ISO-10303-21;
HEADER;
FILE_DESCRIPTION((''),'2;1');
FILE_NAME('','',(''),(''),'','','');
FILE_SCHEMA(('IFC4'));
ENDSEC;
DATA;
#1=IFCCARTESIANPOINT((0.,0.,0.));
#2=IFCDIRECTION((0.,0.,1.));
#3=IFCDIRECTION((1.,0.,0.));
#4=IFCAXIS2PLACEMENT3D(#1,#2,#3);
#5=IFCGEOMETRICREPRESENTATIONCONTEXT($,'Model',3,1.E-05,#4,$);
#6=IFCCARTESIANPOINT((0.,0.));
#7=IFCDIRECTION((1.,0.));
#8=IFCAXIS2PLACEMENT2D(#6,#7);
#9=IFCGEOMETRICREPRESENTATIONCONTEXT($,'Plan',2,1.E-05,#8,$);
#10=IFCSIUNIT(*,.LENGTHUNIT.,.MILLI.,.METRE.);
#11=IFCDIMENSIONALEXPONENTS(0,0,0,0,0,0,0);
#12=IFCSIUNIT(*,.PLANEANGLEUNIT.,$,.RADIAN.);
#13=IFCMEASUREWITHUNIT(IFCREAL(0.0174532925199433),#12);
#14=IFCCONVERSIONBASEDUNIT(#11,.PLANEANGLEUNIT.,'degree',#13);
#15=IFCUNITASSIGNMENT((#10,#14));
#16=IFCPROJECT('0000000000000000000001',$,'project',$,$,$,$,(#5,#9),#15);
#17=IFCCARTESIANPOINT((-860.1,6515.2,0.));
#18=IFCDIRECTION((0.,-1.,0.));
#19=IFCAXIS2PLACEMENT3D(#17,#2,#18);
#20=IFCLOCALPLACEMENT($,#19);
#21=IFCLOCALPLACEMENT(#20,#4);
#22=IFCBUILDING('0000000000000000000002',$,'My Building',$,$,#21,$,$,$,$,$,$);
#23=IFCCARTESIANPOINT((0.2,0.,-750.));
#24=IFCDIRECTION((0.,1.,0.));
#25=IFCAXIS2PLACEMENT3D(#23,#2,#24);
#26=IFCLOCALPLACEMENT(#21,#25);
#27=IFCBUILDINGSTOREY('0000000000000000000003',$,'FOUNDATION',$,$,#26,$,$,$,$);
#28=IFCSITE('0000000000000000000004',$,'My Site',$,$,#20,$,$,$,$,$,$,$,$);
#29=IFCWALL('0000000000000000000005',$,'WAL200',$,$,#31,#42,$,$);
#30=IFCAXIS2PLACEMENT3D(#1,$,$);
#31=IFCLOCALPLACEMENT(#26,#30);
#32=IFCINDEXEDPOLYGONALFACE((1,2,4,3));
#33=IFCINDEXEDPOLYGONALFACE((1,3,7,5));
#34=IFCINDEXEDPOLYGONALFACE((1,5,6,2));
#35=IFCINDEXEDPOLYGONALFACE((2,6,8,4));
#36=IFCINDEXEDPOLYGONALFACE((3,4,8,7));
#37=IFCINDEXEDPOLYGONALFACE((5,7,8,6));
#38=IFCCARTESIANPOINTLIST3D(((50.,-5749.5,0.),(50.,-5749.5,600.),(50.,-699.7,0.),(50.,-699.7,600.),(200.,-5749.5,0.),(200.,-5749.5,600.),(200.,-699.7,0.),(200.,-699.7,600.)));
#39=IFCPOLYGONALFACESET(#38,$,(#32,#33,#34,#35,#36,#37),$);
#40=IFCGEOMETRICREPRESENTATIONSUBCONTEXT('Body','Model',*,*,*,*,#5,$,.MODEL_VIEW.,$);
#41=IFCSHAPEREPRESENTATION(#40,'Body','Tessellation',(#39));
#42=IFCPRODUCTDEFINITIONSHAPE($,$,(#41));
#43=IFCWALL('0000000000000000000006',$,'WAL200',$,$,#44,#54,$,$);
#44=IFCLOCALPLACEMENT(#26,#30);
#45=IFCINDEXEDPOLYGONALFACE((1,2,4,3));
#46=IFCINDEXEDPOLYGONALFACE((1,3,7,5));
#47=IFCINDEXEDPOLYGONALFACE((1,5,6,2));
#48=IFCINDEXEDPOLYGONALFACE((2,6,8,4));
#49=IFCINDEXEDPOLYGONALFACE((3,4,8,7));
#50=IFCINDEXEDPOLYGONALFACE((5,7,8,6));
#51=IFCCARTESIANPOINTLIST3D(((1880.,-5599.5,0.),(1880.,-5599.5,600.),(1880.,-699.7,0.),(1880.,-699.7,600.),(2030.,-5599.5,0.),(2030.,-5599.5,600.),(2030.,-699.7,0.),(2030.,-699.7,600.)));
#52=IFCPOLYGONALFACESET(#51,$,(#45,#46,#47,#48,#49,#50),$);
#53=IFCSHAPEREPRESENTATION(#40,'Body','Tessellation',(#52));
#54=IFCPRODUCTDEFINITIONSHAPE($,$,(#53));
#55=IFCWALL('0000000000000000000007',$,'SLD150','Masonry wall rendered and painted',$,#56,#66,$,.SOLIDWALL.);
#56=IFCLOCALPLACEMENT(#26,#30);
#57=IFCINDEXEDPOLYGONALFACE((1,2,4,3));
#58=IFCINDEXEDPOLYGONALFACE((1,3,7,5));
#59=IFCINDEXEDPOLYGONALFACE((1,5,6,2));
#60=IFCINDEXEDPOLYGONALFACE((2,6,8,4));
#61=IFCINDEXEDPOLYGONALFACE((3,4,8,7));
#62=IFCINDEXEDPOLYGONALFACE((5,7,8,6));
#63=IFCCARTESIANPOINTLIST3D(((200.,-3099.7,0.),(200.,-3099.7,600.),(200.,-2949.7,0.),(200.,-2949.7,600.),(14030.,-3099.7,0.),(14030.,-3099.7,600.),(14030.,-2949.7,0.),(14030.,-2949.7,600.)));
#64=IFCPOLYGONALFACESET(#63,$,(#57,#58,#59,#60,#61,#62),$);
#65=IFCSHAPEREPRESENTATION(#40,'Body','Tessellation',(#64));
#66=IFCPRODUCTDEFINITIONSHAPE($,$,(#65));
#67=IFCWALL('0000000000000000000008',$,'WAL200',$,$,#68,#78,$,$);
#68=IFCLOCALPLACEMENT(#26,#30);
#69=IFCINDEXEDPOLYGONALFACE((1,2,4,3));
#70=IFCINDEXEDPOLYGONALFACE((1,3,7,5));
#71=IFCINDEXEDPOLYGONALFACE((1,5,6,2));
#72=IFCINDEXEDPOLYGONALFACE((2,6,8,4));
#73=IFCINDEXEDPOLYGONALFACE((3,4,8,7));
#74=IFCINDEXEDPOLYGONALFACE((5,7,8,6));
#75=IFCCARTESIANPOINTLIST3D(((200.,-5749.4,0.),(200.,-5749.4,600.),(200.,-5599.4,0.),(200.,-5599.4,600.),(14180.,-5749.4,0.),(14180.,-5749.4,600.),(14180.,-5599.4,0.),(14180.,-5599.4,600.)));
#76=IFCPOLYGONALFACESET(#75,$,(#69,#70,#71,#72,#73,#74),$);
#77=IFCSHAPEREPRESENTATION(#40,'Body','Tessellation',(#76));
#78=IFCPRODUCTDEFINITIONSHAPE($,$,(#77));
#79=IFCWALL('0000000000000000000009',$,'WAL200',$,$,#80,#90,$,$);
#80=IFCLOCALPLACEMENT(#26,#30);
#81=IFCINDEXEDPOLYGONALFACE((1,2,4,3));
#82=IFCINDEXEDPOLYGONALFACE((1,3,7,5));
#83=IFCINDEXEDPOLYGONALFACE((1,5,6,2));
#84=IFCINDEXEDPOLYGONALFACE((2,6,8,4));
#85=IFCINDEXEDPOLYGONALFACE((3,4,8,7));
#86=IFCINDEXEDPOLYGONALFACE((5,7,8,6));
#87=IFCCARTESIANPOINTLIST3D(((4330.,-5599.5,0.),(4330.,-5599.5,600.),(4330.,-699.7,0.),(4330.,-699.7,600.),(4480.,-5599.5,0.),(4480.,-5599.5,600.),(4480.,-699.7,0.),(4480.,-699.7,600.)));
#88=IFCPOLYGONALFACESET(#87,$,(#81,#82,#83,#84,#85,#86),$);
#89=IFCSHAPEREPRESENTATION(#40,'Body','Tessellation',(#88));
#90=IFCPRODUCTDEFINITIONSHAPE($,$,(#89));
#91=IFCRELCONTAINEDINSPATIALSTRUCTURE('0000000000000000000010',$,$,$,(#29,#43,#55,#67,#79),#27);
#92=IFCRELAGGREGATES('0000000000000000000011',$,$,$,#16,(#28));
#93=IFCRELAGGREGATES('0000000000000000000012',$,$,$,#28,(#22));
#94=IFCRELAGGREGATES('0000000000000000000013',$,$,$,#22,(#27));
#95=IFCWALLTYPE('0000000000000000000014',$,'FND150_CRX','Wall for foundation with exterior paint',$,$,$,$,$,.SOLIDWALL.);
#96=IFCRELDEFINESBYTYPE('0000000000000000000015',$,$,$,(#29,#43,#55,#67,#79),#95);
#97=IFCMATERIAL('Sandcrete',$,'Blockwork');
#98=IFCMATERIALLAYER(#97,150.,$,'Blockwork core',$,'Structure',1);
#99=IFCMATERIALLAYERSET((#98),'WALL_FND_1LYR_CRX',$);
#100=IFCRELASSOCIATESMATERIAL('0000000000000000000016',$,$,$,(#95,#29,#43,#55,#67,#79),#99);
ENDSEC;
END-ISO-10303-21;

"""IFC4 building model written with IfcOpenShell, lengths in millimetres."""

from ifc_helpers import new_model, entity, si_unit, converted_unit, frame, origin_with_axes, origin_2d_with_axis, place, context, subcontext, project, spatial, indexed_curve, outline, extrude, material, layer, layer_set, layer_usage, type_object, element, save


model = new_model("IFC4")

# Units and contexts
model_context = context("Model", 3, precision=1e-05, world=origin_with_axes())
plan_context = context("Plan", 2, precision=1e-05, world=origin_2d_with_axis())
body_context = subcontext(model_context, "Body", "Model", "MODEL_VIEW")
ifc_project = project(units=[si_unit("LENGTHUNIT", "METRE", prefix="MILLI"), converted_unit("PLANEANGLEUNIT", "degree", entity("IfcReal", 0.0174532925199433), si_unit("PLANEANGLEUNIT", "RADIAN"), dimensions=[0, 0, 0, 0, 0, 0, 0])], contexts=[model_context, plan_context])

# Site, building, storey
site_placement = place(None, frame((-860.1, 6515.2, 0.0), z_axis=(0.0, 0.0, 1.0), x_axis=(0.0, -1.0, 0.0)))
site = spatial("IfcSite", under=ifc_project, at=site_placement, Name="My Site")
building_placement = place(site_placement, frame((0.0, 0.0, 0.0), z_axis=(0.0, 0.0, 1.0), x_axis=(1.0, 0.0, 0.0)))
building = spatial("IfcBuilding", under=site, at=building_placement, Name="My Building")
storey_placement = place(building_placement, frame((0.2, 0.0, -750.0), z_axis=(0.0, 0.0, 1.0), x_axis=(0.0, 1.0, 0.0)))
storey = spatial("IfcBuildingStorey", under=building, at=storey_placement, Name="FOUNDATION")

# Walls
ifc_material_1 = material(Name="Sandcrete", Category="Blockwork")
ifc_layer_1 = layer(ifc_material_1, 150.0, Name="Blockwork core", Category="Structure", Priority=1)
ifc_layer_set_1 = layer_set([ifc_layer_1], Name="WALL_FND_1LYR_CRX")
ifc_layer_usage_1 = layer_usage(ifc_layer_set_1, "AXIS2", "POSITIVE", 0.0)
wall_type = type_object("IfcWallType", Name="FND150_CRX", Description="Wall for foundation with exterior paint", PredefinedType="SOLIDWALL", material=ifc_layer_set_1)
wall_1_placement = place(storey_placement, frame((50.0, -699.7, 0.0), z_axis=(0.0, 0.0, 1.0), x_axis=(-0.000001, -1.0, 0.0)))
element("IfcWall", 1, at=wall_1_placement, inside=storey, type_object=wall_type, material=ifc_layer_usage_1, Name="WAL200", context=body_context, shape_type="SweptSolid", body=[
    extrude(outline(indexed_curve([(0.0, 0.0), (0.0, 150.0), (5049.8, 150.0), (5049.8, 0.0), (0.0, 0.0)], self_intersect=False)), origin_with_axes(), (0.0, 0.0, 1.0), 600.0),
])
ifc_layer_usage_2 = layer_usage(ifc_layer_set_1, "AXIS2", "POSITIVE", 0.0)
wall_2_placement = place(storey_placement, frame((1880.0, -699.7, 0.0), z_axis=(0.0, 0.0, 1.0), x_axis=(0.0, -1.0, 0.0)))
element("IfcWall", 2, at=wall_2_placement, inside=storey, type_object=wall_type, material=ifc_layer_usage_2, Name="WAL200", context=body_context, shape_type="SweptSolid", body=[
    extrude(outline(indexed_curve([(0.0, 0.0), (0.0, 150.0), (4899.8, 150.0), (4899.8, 0.0), (0.0, 0.0)], self_intersect=False)), origin_with_axes(), (0.0, 0.0, 1.0), 600.0),
])
ifc_layer_usage_3 = layer_usage(ifc_layer_set_1, "AXIS2", "POSITIVE", 0.0)
wall_3_placement = place(storey_placement, frame((200.0, -3099.7, 0.0), z_axis=(0.0, 0.0, 1.0), x_axis=(1.0, 0.0, 0.0)))
element("IfcWall", 3, at=wall_3_placement, inside=storey, type_object=wall_type, material=ifc_layer_usage_3, Name="SLD150", Description="Masonry wall rendered and painted", PredefinedType="SOLIDWALL", context=body_context, shape_type="SweptSolid", body=[
    extrude(outline(indexed_curve([(0.0, 0.0), (0.0, 150.0), (13830.0, 150.0), (13830.0, 0.0), (0.0, 0.0)], self_intersect=False)), origin_with_axes(), (0.0, 0.0, 1.0), 600.0),
])
ifc_layer_usage_4 = layer_usage(ifc_layer_set_1, "AXIS2", "POSITIVE", 0.0)
wall_4_placement = place(storey_placement, frame((200.0, -5749.4, 0.0), z_axis=(0.0, 0.0, 1.0), x_axis=(1.0, 0.0, 0.0)))
element("IfcWall", 4, at=wall_4_placement, inside=storey, type_object=wall_type, material=ifc_layer_usage_4, Name="WAL200", context=body_context, shape_type="SweptSolid", body=[
    extrude(outline(indexed_curve([(0.0, 0.0), (0.0, 150.0), (13980.0, 150.0), (13980.0, 0.0), (0.0, 0.0)], self_intersect=False)), origin_with_axes(), (0.0, 0.0, 1.0), 600.0),
])
ifc_layer_usage_5 = layer_usage(ifc_layer_set_1, "AXIS2", "POSITIVE", 0.0)
wall_5_placement = place(storey_placement, frame((4330.0, -699.7, 0.0), z_axis=(0.0, 0.0, 1.0), x_axis=(0.0, -1.0, 0.0)))
element("IfcWall", 5, at=wall_5_placement, inside=storey, type_object=wall_type, material=ifc_layer_usage_5, Name="WAL200", context=body_context, shape_type="SweptSolid", body=[
    extrude(outline(indexed_curve([(0.0, 0.0), (0.0, 150.0), (4899.8, 150.0), (4899.8, 0.0), (0.0, 0.0)], self_intersect=False)), origin_with_axes(), (0.0, 0.0, 1.0), 600.0),
])

save(model, "model.ifc")
